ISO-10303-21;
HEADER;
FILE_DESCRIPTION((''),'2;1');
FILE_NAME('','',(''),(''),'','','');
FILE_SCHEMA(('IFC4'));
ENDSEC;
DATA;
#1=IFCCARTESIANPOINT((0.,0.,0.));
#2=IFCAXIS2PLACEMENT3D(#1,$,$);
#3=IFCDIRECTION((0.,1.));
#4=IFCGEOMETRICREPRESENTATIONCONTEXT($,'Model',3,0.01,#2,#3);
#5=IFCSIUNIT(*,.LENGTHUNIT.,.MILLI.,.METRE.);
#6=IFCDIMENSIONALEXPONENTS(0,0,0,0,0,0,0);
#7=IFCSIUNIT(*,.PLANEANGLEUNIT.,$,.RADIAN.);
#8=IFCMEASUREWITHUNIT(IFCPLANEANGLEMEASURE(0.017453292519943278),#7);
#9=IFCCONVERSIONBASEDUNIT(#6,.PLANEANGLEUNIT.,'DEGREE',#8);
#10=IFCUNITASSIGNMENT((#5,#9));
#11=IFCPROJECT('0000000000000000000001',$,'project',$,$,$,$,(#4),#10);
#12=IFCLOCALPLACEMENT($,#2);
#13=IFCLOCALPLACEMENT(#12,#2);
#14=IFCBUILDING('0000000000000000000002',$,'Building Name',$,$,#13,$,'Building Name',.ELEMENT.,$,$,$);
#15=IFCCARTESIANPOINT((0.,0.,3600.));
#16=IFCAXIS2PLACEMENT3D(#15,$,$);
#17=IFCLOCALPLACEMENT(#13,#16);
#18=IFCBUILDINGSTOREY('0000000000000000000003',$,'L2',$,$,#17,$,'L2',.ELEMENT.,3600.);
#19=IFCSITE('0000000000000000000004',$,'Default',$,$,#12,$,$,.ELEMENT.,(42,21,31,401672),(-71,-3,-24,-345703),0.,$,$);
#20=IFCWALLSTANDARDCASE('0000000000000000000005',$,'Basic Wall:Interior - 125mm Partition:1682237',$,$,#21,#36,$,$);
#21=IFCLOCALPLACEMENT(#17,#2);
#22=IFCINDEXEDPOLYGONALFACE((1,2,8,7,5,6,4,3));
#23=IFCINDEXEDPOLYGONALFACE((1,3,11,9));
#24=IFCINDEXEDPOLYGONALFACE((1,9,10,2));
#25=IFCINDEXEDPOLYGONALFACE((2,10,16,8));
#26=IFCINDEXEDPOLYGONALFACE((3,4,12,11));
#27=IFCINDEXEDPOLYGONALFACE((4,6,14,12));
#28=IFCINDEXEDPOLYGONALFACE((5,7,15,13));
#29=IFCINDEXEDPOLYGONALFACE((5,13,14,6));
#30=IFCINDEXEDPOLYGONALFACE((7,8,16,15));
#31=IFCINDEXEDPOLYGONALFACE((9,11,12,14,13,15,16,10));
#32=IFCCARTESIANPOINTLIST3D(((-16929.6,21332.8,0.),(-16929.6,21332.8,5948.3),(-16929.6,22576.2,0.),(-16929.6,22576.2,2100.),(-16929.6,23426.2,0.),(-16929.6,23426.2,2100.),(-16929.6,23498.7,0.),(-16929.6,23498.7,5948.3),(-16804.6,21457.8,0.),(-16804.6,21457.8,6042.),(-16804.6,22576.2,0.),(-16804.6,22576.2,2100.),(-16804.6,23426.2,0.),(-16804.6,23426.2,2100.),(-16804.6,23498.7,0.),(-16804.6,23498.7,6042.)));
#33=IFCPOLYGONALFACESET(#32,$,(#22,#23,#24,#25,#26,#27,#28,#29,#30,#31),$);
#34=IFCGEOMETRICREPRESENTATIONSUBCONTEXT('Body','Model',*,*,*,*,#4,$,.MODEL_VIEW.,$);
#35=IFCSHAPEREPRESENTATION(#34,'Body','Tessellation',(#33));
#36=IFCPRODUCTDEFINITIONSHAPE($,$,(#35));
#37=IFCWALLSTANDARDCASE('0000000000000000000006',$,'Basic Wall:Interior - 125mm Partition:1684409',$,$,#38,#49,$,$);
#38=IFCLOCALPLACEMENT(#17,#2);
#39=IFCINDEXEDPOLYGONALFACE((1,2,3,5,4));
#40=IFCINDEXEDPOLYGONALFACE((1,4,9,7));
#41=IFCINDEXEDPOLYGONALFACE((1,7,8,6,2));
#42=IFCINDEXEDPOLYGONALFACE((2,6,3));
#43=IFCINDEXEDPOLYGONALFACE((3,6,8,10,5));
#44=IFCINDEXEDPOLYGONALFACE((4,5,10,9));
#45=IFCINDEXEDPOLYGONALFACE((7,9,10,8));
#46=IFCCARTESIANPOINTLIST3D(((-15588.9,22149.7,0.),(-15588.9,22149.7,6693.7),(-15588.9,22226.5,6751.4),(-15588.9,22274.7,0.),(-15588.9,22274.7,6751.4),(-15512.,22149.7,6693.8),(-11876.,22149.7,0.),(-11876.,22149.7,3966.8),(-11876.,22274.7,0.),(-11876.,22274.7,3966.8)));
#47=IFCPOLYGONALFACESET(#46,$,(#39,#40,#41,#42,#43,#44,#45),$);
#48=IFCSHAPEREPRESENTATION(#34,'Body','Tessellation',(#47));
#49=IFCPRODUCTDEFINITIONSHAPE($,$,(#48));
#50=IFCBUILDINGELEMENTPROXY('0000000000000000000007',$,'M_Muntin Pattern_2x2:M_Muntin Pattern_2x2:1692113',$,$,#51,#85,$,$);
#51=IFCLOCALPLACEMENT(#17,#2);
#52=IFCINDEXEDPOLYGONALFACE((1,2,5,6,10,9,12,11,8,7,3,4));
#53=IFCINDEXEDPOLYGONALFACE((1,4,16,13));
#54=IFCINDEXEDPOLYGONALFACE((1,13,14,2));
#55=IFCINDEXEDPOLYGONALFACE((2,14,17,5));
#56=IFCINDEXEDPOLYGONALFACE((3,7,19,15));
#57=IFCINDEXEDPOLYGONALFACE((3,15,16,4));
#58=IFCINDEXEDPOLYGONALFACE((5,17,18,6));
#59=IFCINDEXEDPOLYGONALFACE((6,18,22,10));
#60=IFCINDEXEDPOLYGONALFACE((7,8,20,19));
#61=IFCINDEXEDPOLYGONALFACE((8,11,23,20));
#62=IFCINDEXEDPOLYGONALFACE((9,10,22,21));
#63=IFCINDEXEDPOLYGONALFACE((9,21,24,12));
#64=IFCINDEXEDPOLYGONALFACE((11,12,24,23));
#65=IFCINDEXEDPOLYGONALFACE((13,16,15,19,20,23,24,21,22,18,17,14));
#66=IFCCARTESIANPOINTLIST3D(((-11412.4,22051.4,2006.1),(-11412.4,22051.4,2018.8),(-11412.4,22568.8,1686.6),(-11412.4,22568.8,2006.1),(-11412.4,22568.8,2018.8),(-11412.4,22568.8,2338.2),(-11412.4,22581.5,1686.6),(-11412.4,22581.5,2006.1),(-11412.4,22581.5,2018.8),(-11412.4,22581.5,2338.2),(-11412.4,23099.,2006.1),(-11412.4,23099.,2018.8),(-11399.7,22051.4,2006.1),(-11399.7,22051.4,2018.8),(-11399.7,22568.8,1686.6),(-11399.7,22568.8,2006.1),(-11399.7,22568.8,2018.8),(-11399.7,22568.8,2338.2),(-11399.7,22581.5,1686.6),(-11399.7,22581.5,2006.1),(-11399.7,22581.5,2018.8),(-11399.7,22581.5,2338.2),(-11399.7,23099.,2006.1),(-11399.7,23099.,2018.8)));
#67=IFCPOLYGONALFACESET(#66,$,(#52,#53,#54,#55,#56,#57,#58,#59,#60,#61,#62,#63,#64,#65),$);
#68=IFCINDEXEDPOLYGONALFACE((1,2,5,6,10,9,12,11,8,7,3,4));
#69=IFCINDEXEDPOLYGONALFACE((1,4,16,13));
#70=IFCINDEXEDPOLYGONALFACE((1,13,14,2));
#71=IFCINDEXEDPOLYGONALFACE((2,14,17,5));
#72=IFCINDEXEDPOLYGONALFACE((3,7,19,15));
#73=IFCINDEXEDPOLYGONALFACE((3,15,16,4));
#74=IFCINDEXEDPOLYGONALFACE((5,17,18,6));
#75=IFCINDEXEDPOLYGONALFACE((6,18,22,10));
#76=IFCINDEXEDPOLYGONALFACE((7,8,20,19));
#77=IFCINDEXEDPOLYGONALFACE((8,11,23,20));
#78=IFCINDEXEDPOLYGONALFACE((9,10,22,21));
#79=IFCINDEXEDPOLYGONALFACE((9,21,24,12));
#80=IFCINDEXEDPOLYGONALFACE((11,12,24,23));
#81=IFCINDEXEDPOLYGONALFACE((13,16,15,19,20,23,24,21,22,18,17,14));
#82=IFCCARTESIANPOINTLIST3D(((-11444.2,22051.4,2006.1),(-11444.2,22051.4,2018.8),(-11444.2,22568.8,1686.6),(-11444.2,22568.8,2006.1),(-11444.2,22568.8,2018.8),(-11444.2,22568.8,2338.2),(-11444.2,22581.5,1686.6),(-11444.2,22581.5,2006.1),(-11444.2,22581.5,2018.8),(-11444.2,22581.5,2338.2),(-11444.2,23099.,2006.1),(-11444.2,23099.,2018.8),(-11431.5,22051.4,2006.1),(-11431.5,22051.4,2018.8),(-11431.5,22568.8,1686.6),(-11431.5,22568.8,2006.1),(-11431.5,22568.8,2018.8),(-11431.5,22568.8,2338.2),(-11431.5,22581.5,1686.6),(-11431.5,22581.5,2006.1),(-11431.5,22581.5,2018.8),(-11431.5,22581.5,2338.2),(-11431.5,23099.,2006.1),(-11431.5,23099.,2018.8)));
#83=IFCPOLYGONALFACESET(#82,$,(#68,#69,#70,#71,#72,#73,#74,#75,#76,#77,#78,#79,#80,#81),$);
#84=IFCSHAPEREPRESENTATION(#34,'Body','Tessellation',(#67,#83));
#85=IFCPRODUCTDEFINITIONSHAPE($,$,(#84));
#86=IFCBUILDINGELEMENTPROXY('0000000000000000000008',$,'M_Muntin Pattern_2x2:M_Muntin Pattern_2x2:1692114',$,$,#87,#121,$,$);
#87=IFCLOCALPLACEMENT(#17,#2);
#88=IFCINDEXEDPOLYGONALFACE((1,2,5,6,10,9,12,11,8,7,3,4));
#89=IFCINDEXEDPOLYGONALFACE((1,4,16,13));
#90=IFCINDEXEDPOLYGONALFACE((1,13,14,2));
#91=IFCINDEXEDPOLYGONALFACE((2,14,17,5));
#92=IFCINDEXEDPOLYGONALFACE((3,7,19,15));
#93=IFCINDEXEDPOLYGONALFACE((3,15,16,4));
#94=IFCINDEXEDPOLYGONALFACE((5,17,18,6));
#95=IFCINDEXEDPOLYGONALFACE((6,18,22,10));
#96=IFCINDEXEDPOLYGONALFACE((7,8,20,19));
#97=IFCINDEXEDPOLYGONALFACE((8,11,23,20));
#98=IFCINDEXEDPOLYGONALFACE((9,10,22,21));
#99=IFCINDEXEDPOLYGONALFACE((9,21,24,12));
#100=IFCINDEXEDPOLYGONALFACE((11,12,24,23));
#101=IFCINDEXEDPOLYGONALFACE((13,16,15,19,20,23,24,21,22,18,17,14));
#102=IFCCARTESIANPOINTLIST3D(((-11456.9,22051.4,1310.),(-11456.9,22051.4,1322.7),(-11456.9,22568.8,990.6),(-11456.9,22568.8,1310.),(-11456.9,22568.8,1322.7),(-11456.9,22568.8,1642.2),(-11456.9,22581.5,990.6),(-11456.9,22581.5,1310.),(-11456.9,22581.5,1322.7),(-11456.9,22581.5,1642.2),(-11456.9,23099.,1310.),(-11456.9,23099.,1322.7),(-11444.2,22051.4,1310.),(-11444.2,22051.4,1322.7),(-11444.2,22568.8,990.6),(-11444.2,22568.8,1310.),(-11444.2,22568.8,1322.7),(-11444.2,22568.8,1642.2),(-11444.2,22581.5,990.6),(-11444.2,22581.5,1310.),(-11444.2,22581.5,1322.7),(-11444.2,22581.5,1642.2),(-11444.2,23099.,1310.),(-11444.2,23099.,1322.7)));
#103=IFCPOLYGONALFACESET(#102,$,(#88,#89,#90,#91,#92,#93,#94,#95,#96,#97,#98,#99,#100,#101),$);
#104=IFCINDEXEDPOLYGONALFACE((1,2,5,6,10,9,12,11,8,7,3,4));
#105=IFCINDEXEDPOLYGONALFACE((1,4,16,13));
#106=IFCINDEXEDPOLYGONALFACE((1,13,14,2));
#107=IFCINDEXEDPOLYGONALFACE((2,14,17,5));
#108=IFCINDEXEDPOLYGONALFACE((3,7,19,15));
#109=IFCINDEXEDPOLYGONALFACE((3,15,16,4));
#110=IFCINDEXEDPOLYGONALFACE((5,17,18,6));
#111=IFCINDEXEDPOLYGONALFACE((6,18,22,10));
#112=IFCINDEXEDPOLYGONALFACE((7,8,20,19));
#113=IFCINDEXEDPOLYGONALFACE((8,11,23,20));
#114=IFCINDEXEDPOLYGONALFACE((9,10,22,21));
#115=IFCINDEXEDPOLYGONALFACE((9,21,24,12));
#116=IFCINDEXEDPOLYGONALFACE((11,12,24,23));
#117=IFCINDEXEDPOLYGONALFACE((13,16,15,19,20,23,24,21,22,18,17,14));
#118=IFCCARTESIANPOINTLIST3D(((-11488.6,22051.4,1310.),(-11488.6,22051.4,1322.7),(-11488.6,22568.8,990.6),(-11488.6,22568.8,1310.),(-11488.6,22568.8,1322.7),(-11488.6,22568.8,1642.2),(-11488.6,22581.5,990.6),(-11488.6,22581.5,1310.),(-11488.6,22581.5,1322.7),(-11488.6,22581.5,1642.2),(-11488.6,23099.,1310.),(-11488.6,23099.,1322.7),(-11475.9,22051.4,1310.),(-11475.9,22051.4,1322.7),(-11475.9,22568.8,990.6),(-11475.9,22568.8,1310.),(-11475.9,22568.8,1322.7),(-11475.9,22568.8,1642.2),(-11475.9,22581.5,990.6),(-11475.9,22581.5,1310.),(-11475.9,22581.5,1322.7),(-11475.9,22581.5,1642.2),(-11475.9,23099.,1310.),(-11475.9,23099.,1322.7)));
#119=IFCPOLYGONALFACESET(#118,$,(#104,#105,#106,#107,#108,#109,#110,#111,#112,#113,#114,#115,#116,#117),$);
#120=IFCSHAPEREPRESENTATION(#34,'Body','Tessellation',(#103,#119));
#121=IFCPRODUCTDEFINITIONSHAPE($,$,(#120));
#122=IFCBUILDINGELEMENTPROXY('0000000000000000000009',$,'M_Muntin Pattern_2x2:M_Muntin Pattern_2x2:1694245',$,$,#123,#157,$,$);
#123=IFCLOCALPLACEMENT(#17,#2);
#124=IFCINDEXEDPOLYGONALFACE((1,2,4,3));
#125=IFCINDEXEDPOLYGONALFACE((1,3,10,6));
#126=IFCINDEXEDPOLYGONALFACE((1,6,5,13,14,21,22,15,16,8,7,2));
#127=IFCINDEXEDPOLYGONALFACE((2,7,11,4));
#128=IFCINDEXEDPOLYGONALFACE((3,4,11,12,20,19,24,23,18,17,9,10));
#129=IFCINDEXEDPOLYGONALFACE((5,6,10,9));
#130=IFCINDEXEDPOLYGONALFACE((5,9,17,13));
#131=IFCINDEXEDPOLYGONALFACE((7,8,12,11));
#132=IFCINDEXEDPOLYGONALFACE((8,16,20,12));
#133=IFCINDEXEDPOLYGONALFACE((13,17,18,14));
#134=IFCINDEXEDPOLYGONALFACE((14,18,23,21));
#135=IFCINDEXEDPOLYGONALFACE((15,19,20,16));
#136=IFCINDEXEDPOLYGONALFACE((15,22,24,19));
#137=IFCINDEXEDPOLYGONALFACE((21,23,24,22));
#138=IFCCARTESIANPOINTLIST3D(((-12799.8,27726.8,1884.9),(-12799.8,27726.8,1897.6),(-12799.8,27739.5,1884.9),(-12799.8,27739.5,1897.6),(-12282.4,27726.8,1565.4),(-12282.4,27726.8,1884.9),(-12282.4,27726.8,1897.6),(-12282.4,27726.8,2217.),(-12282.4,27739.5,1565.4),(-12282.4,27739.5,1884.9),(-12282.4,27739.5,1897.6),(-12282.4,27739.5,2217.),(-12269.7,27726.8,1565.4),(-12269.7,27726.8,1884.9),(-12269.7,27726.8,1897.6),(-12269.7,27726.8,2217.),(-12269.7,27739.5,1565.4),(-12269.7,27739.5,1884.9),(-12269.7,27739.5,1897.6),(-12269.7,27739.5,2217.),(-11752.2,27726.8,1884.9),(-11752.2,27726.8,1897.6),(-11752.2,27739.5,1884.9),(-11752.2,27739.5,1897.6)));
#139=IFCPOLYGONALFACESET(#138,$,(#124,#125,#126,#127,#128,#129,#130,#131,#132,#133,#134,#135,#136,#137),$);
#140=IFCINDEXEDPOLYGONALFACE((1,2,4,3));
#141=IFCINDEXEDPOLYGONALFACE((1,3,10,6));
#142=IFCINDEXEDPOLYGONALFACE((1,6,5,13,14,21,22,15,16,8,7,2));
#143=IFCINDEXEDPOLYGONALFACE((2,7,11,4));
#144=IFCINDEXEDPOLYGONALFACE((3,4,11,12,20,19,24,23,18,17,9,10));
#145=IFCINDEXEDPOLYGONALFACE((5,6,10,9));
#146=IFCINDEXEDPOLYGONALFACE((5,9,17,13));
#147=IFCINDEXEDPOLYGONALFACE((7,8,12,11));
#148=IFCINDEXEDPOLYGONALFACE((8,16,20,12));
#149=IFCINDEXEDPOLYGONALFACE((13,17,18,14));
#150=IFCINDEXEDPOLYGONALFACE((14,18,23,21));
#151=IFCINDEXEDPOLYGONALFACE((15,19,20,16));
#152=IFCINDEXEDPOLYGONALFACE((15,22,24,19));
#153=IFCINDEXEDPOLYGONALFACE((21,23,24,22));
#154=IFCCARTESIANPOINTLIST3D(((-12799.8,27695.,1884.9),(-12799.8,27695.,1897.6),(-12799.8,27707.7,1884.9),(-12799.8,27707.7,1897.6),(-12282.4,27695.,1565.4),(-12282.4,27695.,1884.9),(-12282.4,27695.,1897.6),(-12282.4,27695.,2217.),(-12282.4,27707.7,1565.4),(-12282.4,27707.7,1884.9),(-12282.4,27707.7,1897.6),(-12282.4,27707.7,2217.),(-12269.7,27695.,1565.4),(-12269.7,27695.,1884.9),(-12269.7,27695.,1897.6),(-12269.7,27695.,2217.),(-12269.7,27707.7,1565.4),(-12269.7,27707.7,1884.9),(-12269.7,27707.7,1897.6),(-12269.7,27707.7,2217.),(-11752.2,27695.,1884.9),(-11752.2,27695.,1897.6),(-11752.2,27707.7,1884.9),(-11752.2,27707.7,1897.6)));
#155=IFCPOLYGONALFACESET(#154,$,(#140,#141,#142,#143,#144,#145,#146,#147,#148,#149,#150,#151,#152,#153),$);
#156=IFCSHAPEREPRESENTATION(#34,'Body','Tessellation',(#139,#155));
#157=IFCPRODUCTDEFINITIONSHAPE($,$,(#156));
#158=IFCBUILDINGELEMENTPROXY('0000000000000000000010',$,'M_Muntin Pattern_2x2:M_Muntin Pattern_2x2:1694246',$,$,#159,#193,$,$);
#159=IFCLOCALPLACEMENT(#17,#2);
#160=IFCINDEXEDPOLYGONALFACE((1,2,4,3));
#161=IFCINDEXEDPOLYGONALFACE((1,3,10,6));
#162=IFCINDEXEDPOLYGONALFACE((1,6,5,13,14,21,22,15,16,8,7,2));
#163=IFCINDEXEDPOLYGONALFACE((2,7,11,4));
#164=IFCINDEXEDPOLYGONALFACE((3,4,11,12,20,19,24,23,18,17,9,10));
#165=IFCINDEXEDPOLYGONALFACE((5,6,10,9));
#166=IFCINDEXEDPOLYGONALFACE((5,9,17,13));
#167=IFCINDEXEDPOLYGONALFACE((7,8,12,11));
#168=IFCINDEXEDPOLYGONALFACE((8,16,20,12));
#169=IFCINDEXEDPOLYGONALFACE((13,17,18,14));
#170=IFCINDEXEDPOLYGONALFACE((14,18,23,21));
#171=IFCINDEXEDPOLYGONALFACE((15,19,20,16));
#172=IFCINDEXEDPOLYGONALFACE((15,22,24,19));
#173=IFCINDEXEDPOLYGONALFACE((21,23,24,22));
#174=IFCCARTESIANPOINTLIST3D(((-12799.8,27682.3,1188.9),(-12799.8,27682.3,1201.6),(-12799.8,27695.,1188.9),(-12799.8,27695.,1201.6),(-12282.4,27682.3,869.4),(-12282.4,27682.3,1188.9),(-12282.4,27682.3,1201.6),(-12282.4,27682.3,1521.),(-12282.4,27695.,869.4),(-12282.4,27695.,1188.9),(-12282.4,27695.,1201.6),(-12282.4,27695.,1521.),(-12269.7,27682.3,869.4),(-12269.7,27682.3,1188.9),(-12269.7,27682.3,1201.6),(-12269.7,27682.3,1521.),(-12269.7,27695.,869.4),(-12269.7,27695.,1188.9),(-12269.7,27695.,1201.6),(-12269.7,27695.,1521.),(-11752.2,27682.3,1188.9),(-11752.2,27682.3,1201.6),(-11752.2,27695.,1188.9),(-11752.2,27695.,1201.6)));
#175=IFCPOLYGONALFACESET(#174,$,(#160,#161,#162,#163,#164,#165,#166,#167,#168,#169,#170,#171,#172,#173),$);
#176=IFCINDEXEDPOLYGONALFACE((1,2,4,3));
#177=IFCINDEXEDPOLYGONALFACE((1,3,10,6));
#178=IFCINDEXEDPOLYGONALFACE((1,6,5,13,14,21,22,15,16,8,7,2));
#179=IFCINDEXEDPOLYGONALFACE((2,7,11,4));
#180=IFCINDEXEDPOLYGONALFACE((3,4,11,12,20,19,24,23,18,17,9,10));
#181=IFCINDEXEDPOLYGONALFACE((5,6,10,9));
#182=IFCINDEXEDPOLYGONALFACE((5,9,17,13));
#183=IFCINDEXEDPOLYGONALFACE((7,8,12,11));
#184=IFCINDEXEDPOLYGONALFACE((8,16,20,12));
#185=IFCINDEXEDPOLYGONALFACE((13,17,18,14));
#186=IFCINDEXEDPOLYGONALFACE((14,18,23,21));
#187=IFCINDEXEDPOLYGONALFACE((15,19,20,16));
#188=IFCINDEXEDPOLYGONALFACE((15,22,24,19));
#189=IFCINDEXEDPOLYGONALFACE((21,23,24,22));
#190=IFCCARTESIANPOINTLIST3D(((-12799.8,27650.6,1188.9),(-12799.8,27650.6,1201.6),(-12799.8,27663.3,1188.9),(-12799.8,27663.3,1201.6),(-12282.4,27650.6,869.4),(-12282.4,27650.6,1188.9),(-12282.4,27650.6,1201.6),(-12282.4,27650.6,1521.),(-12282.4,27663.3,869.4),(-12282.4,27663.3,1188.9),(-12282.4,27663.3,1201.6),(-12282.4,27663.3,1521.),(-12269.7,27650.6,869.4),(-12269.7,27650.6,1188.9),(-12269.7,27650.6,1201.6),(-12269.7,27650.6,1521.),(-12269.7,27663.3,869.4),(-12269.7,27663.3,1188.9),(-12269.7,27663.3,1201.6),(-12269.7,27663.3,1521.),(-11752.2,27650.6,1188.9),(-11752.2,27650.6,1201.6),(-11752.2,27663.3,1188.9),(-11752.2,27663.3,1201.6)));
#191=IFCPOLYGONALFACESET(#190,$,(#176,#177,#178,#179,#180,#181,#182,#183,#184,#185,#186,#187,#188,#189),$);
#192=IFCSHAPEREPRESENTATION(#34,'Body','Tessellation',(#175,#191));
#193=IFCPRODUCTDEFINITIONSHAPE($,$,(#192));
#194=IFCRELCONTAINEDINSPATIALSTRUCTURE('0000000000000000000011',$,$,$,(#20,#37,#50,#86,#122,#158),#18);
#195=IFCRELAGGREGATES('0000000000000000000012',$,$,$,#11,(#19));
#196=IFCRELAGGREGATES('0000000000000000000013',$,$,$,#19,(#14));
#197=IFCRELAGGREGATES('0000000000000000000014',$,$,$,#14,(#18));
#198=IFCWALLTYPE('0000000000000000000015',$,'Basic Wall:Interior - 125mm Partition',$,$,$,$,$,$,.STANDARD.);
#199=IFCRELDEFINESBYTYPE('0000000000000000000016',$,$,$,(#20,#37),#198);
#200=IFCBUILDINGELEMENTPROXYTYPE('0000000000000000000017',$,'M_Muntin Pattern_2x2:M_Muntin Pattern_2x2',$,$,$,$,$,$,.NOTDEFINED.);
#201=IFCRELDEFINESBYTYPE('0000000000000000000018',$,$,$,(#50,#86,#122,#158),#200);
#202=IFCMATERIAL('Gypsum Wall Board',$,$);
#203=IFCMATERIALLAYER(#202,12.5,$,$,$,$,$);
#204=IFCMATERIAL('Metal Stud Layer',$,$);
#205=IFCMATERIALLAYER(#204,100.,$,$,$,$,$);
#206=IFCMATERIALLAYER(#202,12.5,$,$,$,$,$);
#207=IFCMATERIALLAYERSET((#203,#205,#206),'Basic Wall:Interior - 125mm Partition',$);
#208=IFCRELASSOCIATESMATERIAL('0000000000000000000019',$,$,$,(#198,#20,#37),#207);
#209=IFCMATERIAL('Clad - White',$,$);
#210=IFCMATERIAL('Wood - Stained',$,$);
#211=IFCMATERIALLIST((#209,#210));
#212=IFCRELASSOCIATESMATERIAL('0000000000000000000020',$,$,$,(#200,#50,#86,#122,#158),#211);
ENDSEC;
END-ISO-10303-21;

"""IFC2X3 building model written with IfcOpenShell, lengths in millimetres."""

from ifc_helpers import new_model, entity, si_unit, converted_unit, direction, frame, frame_2d, origin, place, context, subcontext, project, spatial, polyline, rectangle, outline, extrude, clip, bounded_halfspace, source, transform, mapped, material, material_list, layer, layer_set, layer_usage, type_object, type_shapes, element, save


model = new_model("IFC2X3")

# Units and contexts
model_context = context("Model", 3, precision=0.01, world=origin(), true_north=direction((0.0, 1.0)))
body_context = subcontext(model_context, "Body", "Model", "MODEL_VIEW")
ifc_project = project(units=[si_unit("LENGTHUNIT", "METRE", prefix="MILLI"), converted_unit("PLANEANGLEUNIT", "DEGREE", entity("IfcPlaneAngleMeasure", 0.017453292519943278), si_unit("PLANEANGLEUNIT", "RADIAN"), dimensions=[0, 0, 0, 0, 0, 0, 0])], contexts=[model_context])

# Site, building, storey
site_placement = place(None, origin())
site = spatial("IfcSite", under=ifc_project, at=site_placement, Name="Default", CompositionType="ELEMENT", RefLatitude=(42, 21, 31, 401672), RefLongitude=(-71, -3, -24, -345703), RefElevation=0.0)
building_placement = place(site_placement, origin())
building = spatial("IfcBuilding", under=site, at=building_placement, Name="Building Name", LongName="Building Name", CompositionType="ELEMENT")
storey_placement = place(building_placement, frame((0.0, 0.0, 3600.0)))
storey = spatial("IfcBuildingStorey", under=building, at=storey_placement, Name="L2", LongName="L2", CompositionType="ELEMENT", Elevation=3600.0)

# Shared definitions
ifc_material_1 = material(Name="Gypsum Wall Board")
ifc_material_2 = material(Name="Wood - Stained")

# Wall, opening
ifc_layer_1 = layer(ifc_material_1, 12.5)
ifc_material_3 = material(Name="Metal Stud Layer")
ifc_layer_2 = layer(ifc_material_3, 100.0)
ifc_layer_3 = layer(ifc_material_1, 12.5)
ifc_layer_set_1 = layer_set([ifc_layer_1, ifc_layer_2, ifc_layer_3], Name="Basic Wall:Interior - 125mm Partition")
ifc_layer_usage_1 = layer_usage(ifc_layer_set_1, "AXIS2", "NEGATIVE", 62.5)
wall_type_1 = type_object("IfcWallType", Name="Basic Wall:Interior - 125mm Partition", PredefinedType="STANDARD", material=ifc_layer_set_1)
wall_1_placement = place(storey_placement, frame((-16867.1, 21332.8, 0.0), z_axis=(0.0, 0.0, 1.0), x_axis=(0.0, 1.0, 0.0)))
wall_1 = element("IfcWallStandardCase", 1, at=wall_1_placement, inside=storey, type_object=wall_type_1, material=ifc_layer_usage_1, Name="Basic Wall:Interior - 125mm Partition:1682237", context=body_context, shape_type="Clipping", body=[
    clip(extrude(outline(polyline([(125.0, -62.5), (2165.9, -62.5), (2165.9, 62.5), (0.0, 62.5), (125.0, -62.5)])), origin(), (0.0, 0.0, 1.0), 6042.0), bounded_halfspace(frame((125.0, -62.5, 6042.0), z_axis=(0.0, 0.6, 0.8), x_axis=(-1.0, 0.0, 0.0)), False, frame((125.0, -62.5, 6042.0)), polyline([(0.0, 0.0), (2040.9, 0.0), (2040.9, 125.0), (-125.0, 125.0), (0.0, 0.0)]))),
])
opening_1_placement = place(wall_1_placement, frame((1243.4, -62.5, 0.0)))
element("IfcOpeningElement", 2, at=opening_1_placement, cuts=wall_1, ObjectType="Opening", context=body_context, shape_type="SweptSolid", body=[
    extrude(rectangle(XDim=2100.0, YDim=850.0, at=frame_2d((1050.0, 425.0), x_axis=(1.0, 0.0))), frame((0.0, 0.0, 0.0), z_axis=(0.0, 1.0, 0.0), x_axis=(0.0, 0.0, 1.0)), (0.0, 0.0, 1.0), 125.0),
])

# Wall
ifc_layer_usage_2 = layer_usage(ifc_layer_set_1, "AXIS2", "NEGATIVE", 62.5)
wall_2_placement = place(storey_placement, frame((-15588.9, 22212.2, 0.0)))
element("IfcWallStandardCase", 3, at=wall_2_placement, inside=storey, type_object=wall_type_1, material=ifc_layer_usage_2, Name="Basic Wall:Interior - 125mm Partition:1684409", context=body_context, shape_type="Clipping", body=[
    clip(clip(extrude(rectangle(XDim=3712.8, YDim=125.0, at=frame_2d((1856.4, 0.0), x_axis=(-1.0, 0.0))), origin(), (0.0, 0.0, 1.0), 6751.4), bounded_halfspace(frame((0.0, -62.5, 6693.7), z_axis=(0.0, -0.6, 0.8), x_axis=(1.0, 0.0, 0.0)), False, frame((0.0, -62.5, 6693.7)), polyline([(0.0, 0.0), (76.8, 0.0), (0.0, 76.8), (0.0, 0.0)]))), bounded_halfspace(frame((76.8, -62.5, 6693.8), z_axis=(0.6, 0.0, 0.8), x_axis=(0.0, 1.0, 0.0)), False, frame((76.8, -62.5, 6693.8)), polyline([(0.0, 0.0), (3636.0, 0.0), (3636.0, 125.0), (-76.8, 125.0), (-76.8, 76.8), (0.0, 0.0)]))),
])

# Building element proxies
ifc_material_4 = material(Name="Clad - White")
ifc_material_list_1 = material_list([ifc_material_4, ifc_material_2])
building_element_proxy_type_1 = type_object("IfcBuildingElementProxyType", Name="M_Muntin Pattern_2x2:M_Muntin Pattern_2x2", PredefinedType="NOTDEFINED", material=ifc_material_list_1)
shared_shape_1 = source(origin(), body_context, "Body", "SweptSolid", [
    extrude(outline(polyline([(6.4, -6.4), (325.8, -6.4), (325.8, 6.3), (6.4, 6.3), (6.4, 523.8), (-6.3, 523.8), (-6.3, 6.3), (-325.8, 6.3), (-325.8, -6.4), (-6.3, -6.4), (-6.3, -523.8), (6.4, -523.8), (6.4, -6.4)])), frame((0.0, 9.5, 325.8), z_axis=(0.0, 1.0, 0.0), x_axis=(0.0, 0.0, 1.0)), (0.0, 0.0, 1.0), 12.7),
    extrude(outline(polyline([(6.4, -6.4), (325.8, -6.4), (325.8, 6.3), (6.4, 6.3), (6.4, 523.8), (-6.3, 523.8), (-6.3, 6.3), (-325.8, 6.3), (-325.8, -6.4), (-6.3, -6.4), (-6.3, -523.8), (6.4, -523.8), (6.4, -6.4)])), frame((0.0, -22.2, 325.8), z_axis=(0.0, 1.0, 0.0), x_axis=(0.0, 0.0, 1.0)), (0.0, 0.0, 1.0), 12.7),
])
type_shapes(building_element_proxy_type_1, [shared_shape_1])
for number, where, z_axis, x_axis, name in (
    (4, (-11422.0, 22575.2, 1686.6), (0.0, 0.0, 1.0), (0.0, -1.0, 0.0), "M_Muntin Pattern_2x2:M_Muntin Pattern_2x2:1692113"),
    (5, (-11466.4, 22575.2, 990.6), (0.0, 0.0, 1.0), (0.0, -1.0, 0.0), "M_Muntin Pattern_2x2:M_Muntin Pattern_2x2:1692114"),
):
    element("IfcBuildingElementProxy", number, at=place(storey_placement, frame(where, z_axis=z_axis, x_axis=x_axis)), inside=storey, type_object=building_element_proxy_type_1, material=ifc_material_list_1, Name=name, context=body_context, shape_type="MappedRepresentation", body=[
        mapped(shared_shape_1, transform((0.0, 0.0, 0.0), scale=1.0)),
    ])
for number, where, name in (
    (6, (-12276.0, 27717.2, 1565.4), "M_Muntin Pattern_2x2:M_Muntin Pattern_2x2:1694245"),
    (7, (-12276.0, 27672.8, 869.4), "M_Muntin Pattern_2x2:M_Muntin Pattern_2x2:1694246"),
):
    element("IfcBuildingElementProxy", number, at=place(storey_placement, frame(where)), inside=storey, type_object=building_element_proxy_type_1, material=ifc_material_list_1, Name=name, context=body_context, shape_type="MappedRepresentation", body=[
        mapped(shared_shape_1, transform((0.0, 0.0, 0.0), scale=1.0)),
    ])

save(model, "model.ifc")
